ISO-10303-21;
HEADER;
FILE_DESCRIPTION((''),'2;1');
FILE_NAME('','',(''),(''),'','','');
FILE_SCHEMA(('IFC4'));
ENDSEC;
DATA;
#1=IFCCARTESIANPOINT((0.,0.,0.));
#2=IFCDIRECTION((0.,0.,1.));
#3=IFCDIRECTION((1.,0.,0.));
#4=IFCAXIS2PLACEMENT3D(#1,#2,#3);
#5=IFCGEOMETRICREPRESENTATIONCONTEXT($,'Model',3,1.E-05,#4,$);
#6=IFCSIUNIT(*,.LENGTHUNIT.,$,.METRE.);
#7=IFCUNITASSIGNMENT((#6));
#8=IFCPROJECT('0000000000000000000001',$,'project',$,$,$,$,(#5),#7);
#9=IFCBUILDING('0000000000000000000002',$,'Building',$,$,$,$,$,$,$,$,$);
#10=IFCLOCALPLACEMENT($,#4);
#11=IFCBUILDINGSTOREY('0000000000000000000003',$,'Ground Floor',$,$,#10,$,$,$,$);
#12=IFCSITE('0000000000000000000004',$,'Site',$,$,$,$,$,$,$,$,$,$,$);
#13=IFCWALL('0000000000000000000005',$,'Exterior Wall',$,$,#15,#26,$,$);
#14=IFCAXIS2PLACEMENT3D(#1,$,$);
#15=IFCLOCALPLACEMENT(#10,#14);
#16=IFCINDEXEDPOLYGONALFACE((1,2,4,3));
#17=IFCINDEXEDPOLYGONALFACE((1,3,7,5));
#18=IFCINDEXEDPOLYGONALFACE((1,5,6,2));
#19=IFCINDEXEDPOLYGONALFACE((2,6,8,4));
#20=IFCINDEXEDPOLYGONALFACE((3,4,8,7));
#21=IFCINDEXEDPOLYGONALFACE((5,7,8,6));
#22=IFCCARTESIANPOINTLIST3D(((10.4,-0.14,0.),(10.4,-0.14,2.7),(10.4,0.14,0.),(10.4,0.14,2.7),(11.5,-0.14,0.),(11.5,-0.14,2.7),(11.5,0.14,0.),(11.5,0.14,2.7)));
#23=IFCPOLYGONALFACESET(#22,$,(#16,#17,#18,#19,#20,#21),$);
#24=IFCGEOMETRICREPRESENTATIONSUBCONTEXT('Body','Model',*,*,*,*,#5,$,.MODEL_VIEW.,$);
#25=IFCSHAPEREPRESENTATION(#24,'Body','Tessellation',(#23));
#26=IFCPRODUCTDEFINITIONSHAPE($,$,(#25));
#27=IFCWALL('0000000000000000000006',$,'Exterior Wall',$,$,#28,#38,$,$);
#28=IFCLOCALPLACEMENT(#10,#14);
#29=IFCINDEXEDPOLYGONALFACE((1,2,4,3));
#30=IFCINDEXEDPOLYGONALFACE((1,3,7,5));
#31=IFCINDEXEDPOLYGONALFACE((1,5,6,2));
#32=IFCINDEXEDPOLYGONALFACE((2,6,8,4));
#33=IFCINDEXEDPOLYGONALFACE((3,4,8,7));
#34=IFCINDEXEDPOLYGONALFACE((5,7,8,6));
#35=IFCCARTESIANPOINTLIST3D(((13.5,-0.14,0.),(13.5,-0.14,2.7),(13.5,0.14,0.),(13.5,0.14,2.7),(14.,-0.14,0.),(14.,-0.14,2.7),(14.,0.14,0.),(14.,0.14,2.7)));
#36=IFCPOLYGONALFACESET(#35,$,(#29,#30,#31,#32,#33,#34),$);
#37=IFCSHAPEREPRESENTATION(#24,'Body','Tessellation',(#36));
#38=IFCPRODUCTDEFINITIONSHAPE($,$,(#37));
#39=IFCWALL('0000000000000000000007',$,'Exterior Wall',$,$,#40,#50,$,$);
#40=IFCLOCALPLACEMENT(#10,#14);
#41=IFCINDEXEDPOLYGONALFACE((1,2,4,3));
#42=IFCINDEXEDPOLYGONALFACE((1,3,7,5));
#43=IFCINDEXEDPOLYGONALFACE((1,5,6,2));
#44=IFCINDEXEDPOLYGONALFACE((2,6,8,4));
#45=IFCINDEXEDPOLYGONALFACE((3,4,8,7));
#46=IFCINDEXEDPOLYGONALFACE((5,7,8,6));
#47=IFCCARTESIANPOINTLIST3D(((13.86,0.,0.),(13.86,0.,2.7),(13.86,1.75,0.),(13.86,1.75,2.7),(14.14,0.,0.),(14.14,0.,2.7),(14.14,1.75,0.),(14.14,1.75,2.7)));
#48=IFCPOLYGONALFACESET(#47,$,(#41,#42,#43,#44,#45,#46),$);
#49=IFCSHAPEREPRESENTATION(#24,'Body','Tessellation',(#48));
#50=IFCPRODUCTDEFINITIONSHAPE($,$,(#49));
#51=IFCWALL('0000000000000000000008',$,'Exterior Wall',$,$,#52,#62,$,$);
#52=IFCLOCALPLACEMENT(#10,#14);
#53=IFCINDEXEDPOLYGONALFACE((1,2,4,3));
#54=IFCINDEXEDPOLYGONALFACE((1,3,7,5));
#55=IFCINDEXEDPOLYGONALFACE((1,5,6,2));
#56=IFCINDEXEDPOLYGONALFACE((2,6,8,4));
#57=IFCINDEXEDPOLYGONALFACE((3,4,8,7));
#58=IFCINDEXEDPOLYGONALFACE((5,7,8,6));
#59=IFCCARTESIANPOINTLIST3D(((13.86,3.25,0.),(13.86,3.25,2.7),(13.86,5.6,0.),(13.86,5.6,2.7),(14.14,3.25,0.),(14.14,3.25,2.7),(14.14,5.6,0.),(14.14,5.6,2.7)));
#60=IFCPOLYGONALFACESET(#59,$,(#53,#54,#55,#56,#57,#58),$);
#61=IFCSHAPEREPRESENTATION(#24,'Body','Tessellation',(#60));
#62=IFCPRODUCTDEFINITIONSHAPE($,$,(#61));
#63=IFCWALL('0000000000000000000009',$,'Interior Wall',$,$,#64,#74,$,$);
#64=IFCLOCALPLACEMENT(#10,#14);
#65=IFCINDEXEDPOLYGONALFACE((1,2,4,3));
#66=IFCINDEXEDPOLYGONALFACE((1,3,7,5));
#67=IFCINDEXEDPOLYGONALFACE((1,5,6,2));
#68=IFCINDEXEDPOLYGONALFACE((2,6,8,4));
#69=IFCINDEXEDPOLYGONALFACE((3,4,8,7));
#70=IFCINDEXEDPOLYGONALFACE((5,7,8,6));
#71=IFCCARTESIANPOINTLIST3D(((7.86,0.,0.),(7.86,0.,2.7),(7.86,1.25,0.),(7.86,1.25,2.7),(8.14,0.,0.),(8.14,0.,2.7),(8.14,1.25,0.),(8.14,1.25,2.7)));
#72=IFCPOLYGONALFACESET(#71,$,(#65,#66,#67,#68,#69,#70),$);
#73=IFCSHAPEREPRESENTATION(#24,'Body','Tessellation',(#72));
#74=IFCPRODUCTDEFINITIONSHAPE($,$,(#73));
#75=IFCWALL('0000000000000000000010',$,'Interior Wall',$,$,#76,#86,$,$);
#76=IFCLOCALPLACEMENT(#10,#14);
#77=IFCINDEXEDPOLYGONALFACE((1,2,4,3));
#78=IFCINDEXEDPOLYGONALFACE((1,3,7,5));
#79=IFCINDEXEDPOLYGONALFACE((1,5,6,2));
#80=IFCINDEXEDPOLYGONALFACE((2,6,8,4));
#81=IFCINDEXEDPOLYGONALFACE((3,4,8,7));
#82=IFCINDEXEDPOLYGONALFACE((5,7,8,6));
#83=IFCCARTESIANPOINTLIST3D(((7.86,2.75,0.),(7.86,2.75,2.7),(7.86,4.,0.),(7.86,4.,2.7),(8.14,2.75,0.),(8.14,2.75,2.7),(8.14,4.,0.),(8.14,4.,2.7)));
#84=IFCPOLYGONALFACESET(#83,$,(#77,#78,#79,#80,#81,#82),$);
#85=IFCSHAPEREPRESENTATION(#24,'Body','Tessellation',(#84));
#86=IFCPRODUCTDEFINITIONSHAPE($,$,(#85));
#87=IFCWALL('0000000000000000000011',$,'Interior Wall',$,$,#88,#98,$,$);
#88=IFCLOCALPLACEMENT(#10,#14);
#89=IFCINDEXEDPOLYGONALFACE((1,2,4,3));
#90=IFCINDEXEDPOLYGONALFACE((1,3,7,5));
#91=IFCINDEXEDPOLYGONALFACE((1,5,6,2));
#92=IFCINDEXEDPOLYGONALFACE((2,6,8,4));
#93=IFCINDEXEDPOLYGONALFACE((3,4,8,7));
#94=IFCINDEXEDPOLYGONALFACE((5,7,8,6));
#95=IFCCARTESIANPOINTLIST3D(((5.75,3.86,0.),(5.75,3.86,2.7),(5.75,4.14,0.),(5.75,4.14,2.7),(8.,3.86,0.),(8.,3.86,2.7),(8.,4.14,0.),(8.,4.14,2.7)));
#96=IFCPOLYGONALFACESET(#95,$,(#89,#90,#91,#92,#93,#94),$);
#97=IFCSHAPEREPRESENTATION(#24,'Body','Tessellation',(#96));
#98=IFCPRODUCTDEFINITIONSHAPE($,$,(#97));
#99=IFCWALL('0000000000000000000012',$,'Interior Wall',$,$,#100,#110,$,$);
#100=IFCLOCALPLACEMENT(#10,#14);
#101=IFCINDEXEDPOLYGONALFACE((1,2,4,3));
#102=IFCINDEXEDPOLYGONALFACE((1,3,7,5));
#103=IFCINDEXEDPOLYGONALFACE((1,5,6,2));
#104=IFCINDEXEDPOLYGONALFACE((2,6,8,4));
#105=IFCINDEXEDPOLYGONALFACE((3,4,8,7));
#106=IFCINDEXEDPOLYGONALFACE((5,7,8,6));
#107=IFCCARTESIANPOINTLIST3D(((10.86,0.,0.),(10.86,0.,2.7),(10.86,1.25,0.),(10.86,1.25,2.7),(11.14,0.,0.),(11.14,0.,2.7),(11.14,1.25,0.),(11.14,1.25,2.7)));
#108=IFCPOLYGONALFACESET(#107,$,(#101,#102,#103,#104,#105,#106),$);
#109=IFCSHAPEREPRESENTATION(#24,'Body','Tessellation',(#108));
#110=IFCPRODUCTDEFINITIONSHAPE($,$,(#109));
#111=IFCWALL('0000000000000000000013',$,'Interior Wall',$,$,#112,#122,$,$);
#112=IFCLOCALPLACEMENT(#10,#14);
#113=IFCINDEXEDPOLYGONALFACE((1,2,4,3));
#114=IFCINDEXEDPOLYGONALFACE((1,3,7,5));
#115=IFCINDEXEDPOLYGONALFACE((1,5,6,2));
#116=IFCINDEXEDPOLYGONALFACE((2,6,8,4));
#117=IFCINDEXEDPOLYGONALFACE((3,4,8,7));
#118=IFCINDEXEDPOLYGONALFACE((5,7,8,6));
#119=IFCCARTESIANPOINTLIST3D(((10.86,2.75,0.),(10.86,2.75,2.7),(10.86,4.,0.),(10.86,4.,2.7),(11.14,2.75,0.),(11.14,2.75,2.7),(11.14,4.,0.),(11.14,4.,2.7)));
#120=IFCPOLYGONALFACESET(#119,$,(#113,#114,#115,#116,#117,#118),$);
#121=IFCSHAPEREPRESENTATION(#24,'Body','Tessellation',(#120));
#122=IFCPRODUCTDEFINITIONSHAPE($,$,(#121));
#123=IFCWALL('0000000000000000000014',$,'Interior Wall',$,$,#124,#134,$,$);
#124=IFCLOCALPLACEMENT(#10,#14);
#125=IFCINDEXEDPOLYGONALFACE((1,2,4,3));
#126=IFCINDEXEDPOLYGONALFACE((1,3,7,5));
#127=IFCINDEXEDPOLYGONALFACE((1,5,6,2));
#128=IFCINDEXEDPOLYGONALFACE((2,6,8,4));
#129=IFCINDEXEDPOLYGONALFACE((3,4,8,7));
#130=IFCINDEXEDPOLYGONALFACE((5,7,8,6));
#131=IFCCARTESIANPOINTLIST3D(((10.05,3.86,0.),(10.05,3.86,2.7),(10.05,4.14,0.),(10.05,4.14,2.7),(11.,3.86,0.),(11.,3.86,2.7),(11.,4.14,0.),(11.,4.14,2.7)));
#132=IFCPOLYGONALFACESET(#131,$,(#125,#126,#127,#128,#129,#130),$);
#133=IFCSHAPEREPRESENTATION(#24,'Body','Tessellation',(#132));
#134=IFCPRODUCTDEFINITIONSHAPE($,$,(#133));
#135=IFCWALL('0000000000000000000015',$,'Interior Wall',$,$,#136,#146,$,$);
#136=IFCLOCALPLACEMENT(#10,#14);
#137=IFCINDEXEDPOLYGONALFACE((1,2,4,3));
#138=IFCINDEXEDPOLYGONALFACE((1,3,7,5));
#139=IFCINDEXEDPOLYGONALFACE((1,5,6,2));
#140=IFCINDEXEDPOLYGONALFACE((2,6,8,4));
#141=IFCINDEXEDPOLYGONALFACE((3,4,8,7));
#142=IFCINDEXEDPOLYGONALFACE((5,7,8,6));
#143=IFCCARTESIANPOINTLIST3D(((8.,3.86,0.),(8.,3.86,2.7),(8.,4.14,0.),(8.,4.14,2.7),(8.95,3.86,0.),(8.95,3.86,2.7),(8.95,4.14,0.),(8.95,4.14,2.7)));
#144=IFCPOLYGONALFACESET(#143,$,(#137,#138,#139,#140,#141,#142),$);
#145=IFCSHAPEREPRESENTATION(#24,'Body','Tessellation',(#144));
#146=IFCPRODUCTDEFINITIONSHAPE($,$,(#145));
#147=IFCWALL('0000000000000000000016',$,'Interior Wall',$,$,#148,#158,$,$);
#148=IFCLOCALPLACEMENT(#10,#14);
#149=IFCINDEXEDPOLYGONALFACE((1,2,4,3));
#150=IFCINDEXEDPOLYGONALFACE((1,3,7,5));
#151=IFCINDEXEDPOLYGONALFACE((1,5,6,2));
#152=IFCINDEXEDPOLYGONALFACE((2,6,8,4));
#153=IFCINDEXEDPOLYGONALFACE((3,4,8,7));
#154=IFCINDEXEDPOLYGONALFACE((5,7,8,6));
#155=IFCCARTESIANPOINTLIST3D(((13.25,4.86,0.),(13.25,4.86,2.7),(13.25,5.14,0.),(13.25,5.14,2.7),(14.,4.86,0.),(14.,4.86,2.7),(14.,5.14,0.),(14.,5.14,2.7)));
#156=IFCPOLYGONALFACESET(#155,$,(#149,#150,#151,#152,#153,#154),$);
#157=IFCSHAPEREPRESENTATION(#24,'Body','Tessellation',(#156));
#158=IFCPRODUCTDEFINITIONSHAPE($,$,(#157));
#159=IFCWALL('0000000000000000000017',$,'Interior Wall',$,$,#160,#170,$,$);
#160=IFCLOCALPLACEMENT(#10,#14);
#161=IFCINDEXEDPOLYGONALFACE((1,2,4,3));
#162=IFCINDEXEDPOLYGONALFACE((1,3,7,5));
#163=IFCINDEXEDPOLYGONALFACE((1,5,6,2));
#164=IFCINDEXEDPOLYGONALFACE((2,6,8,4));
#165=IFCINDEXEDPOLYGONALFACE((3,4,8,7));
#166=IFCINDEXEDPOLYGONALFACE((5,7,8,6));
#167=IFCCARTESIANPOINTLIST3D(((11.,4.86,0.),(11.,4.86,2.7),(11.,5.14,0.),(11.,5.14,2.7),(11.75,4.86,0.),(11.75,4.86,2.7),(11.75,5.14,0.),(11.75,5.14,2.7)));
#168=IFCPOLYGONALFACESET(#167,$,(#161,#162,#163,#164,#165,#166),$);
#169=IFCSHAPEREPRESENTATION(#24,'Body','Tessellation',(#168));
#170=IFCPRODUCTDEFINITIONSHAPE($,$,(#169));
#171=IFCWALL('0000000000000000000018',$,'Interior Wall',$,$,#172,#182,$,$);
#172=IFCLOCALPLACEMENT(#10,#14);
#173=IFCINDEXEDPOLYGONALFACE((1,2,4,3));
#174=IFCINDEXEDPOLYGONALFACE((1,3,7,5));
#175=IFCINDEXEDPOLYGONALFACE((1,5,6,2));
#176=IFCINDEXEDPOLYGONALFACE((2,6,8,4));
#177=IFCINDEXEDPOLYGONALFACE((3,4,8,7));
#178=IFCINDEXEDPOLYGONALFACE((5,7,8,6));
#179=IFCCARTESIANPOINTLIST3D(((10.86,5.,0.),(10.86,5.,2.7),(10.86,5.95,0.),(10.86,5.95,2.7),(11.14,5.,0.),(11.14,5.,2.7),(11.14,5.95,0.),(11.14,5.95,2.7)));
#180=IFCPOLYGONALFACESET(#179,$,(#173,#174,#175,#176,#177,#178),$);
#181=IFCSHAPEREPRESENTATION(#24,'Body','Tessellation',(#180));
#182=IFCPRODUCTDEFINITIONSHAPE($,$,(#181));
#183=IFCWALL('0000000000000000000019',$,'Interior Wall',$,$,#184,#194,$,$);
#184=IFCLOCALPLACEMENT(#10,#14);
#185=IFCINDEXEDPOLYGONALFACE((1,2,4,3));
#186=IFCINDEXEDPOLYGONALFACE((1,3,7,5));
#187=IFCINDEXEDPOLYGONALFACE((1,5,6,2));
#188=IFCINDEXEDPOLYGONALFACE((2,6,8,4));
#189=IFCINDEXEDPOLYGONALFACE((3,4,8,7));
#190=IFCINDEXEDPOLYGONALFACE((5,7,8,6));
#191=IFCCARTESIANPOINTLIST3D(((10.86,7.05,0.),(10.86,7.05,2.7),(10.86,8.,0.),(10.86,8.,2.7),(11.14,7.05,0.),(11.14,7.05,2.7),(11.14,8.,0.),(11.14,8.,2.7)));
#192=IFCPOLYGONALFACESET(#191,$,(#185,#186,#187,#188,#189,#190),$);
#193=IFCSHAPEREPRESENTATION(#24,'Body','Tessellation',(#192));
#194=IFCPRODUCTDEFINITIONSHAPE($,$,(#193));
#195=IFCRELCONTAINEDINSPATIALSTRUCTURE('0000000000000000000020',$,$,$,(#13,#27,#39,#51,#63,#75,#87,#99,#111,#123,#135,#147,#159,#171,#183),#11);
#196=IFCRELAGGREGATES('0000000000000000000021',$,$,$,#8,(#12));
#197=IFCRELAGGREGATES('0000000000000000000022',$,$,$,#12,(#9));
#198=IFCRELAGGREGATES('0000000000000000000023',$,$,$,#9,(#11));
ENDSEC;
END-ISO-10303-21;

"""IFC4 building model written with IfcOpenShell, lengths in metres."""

from ifc_helpers import new_model, si_unit, frame, origin_with_axes, place, context, subcontext, project, spatial, indexed_curve, outline, extrude, element, save


model = new_model("IFC4")

# Units and contexts
model_context = context("Model", 3, precision=1e-05, world=origin_with_axes())
body_context = subcontext(model_context, "Body", "Model", "MODEL_VIEW")
ifc_project = project(units=[si_unit("LENGTHUNIT", "METRE")], contexts=[model_context])

# Site, building, storey
site = spatial("IfcSite", under=ifc_project, Name="Site")
building = spatial("IfcBuilding", under=site, Name="Building")
storey_placement = place(None, origin_with_axes())
storey = spatial("IfcBuildingStorey", under=building, at=storey_placement, Name="Ground Floor")

# Walls
wall_1_placement = place(storey_placement, frame((10.4, 0.0, 0.0), z_axis=(0.0, 0.0, 1.0), x_axis=(1.0, 0.0, 0.0)))
element("IfcWall", 1, at=wall_1_placement, inside=storey, Name="Exterior Wall", context=body_context, shape_type="SweptSolid", body=[
    extrude(outline(indexed_curve([(0.0, 0.0), (0.0, 0.28), (1.1, 0.28), (1.1, 0.0), (0.0, 0.0)], self_intersect=False)), frame((0.0, -0.14, 0.0), z_axis=(0.0, 0.0, 1.0), x_axis=(1.0, 0.0, 0.0)), (0.0, 0.0, 1.0), 2.7),
])
wall_2_placement = place(storey_placement, frame((13.5, 0.0, 0.0), z_axis=(0.0, 0.0, 1.0), x_axis=(1.0, 0.0, 0.0)))
element("IfcWall", 2, at=wall_2_placement, inside=storey, Name="Exterior Wall", context=body_context, shape_type="SweptSolid", body=[
    extrude(outline(indexed_curve([(0.0, 0.0), (0.0, 0.28), (0.5, 0.28), (0.5, 0.0), (0.0, 0.0)], self_intersect=False)), frame((0.0, -0.14, 0.0), z_axis=(0.0, 0.0, 1.0), x_axis=(1.0, 0.0, 0.0)), (0.0, 0.0, 1.0), 2.7),
])
wall_3_placement = place(storey_placement, frame((14.0, 0.0, 0.0), z_axis=(0.0, 0.0, 1.0), x_axis=(0.0, 1.0, 0.0)))
element("IfcWall", 3, at=wall_3_placement, inside=storey, Name="Exterior Wall", context=body_context, shape_type="SweptSolid", body=[
    extrude(outline(indexed_curve([(0.0, 0.0), (0.0, 0.28), (1.75, 0.28), (1.75, 0.0), (0.0, 0.0)], self_intersect=False)), frame((0.0, -0.14, 0.0), z_axis=(0.0, 0.0, 1.0), x_axis=(1.0, 0.0, 0.0)), (0.0, 0.0, 1.0), 2.7),
])
wall_4_placement = place(storey_placement, frame((14.0, 3.25, 0.0), z_axis=(0.0, 0.0, 1.0), x_axis=(0.0, 1.0, 0.0)))
element("IfcWall", 4, at=wall_4_placement, inside=storey, Name="Exterior Wall", context=body_context, shape_type="SweptSolid", body=[
    extrude(outline(indexed_curve([(0.0, 0.0), (0.0, 0.28), (2.35, 0.28), (2.35, 0.0), (0.0, 0.0)], self_intersect=False)), frame((0.0, -0.14, 0.0), z_axis=(0.0, 0.0, 1.0), x_axis=(1.0, 0.0, 0.0)), (0.0, 0.0, 1.0), 2.7),
])
for number, where, z_axis, x_axis, name in (
    (5, (8.0, 0.0, 0.0), (0.0, 0.0, 1.0), (0.0, 1.0, 0.0), "Interior Wall"),
    (6, (8.0, 2.75, 0.0), (0.0, 0.0, 1.0), (0.0, 1.0, 0.0), "Interior Wall"),
):
    element("IfcWall", number, at=place(storey_placement, frame(where, z_axis=z_axis, x_axis=x_axis)), inside=storey, Name=name, context=body_context, shape_type="SweptSolid", body=[
        extrude(outline(indexed_curve([(0.0, 0.0), (0.0, 0.28), (1.25, 0.28), (1.25, 0.0), (0.0, 0.0)], self_intersect=False)), frame((0.0, -0.14, 0.0), z_axis=(0.0, 0.0, 1.0), x_axis=(1.0, 0.0, 0.0)), (0.0, 0.0, 1.0), 2.7),
    ])
wall_5_placement = place(storey_placement, frame((8.0, 4.0, 0.0), z_axis=(0.0, 0.0, 1.0), x_axis=(-1.0, 0.0, 0.0)))
element("IfcWall", 7, at=wall_5_placement, inside=storey, Name="Interior Wall", context=body_context, shape_type="SweptSolid", body=[
    extrude(outline(indexed_curve([(0.0, 0.0), (0.0, 0.28), (2.25, 0.28), (2.25, 0.0), (0.0, 0.0)], self_intersect=False)), frame((0.0, -0.14, 0.0), z_axis=(0.0, 0.0, 1.0), x_axis=(1.0, 0.0, 0.0)), (0.0, 0.0, 1.0), 2.7),
])
for number, where, z_axis, x_axis, name in (
    (8, (11.0, 0.0, 0.0), (0.0, 0.0, 1.0), (0.0, 1.0, 0.0), "Interior Wall"),
    (9, (11.0, 2.75, 0.0), (0.0, 0.0, 1.0), (0.0, 1.0, 0.0), "Interior Wall"),
):
    element("IfcWall", number, at=place(storey_placement, frame(where, z_axis=z_axis, x_axis=x_axis)), inside=storey, Name=name, context=body_context, shape_type="SweptSolid", body=[
        extrude(outline(indexed_curve([(0.0, 0.0), (0.0, 0.28), (1.25, 0.28), (1.25, 0.0), (0.0, 0.0)], self_intersect=False)), frame((0.0, -0.14, 0.0), z_axis=(0.0, 0.0, 1.0), x_axis=(1.0, 0.0, 0.0)), (0.0, 0.0, 1.0), 2.7),
    ])
for number, where, z_axis, x_axis, name in (
    (10, (11.0, 4.0, 0.0), (0.0, 0.0, 1.0), (-1.0, 0.0, 0.0), "Interior Wall"),
    (11, (8.95, 4.0, 0.0), (0.0, 0.0, 1.0), (-1.0, 0.0, 0.0), "Interior Wall"),
):
    element("IfcWall", number, at=place(storey_placement, frame(where, z_axis=z_axis, x_axis=x_axis)), inside=storey, Name=name, context=body_context, shape_type="SweptSolid", body=[
        extrude(outline(indexed_curve([(0.0, 0.0), (0.0, 0.28), (0.95, 0.28), (0.95, 0.0), (0.0, 0.0)], self_intersect=False)), frame((0.0, -0.14, 0.0), z_axis=(0.0, 0.0, 1.0), x_axis=(1.0, 0.0, 0.0)), (0.0, 0.0, 1.0), 2.7),
    ])
for number, where, z_axis, x_axis, name in (
    (12, (14.0, 5.0, 0.0), (0.0, 0.0, 1.0), (-1.0, 0.0, 0.0), "Interior Wall"),
    (13, (11.75, 5.0, 0.0), (0.0, 0.0, 1.0), (-1.0, 0.0, 0.0), "Interior Wall"),
):
    element("IfcWall", number, at=place(storey_placement, frame(where, z_axis=z_axis, x_axis=x_axis)), inside=storey, Name=name, context=body_context, shape_type="SweptSolid", body=[
        extrude(outline(indexed_curve([(0.0, 0.0), (0.0, 0.28), (0.75, 0.28), (0.75, 0.0), (0.0, 0.0)], self_intersect=False)), frame((0.0, -0.14, 0.0), z_axis=(0.0, 0.0, 1.0), x_axis=(1.0, 0.0, 0.0)), (0.0, 0.0, 1.0), 2.7),
    ])
for number, where, z_axis, x_axis, name in (
    (14, (11.0, 5.0, 0.0), (0.0, 0.0, 1.0), (0.0, 1.0, 0.0), "Interior Wall"),
    (15, (11.0, 7.05, 0.0), (0.0, 0.0, 1.0), (0.0, 1.0, 0.0), "Interior Wall"),
):
    element("IfcWall", number, at=place(storey_placement, frame(where, z_axis=z_axis, x_axis=x_axis)), inside=storey, Name=name, context=body_context, shape_type="SweptSolid", body=[
        extrude(outline(indexed_curve([(0.0, 0.0), (0.0, 0.28), (0.95, 0.28), (0.95, 0.0), (0.0, 0.0)], self_intersect=False)), frame((0.0, -0.14, 0.0), z_axis=(0.0, 0.0, 1.0), x_axis=(1.0, 0.0, 0.0)), (0.0, 0.0, 1.0), 2.7),
    ])

save(model, "model.ifc")
